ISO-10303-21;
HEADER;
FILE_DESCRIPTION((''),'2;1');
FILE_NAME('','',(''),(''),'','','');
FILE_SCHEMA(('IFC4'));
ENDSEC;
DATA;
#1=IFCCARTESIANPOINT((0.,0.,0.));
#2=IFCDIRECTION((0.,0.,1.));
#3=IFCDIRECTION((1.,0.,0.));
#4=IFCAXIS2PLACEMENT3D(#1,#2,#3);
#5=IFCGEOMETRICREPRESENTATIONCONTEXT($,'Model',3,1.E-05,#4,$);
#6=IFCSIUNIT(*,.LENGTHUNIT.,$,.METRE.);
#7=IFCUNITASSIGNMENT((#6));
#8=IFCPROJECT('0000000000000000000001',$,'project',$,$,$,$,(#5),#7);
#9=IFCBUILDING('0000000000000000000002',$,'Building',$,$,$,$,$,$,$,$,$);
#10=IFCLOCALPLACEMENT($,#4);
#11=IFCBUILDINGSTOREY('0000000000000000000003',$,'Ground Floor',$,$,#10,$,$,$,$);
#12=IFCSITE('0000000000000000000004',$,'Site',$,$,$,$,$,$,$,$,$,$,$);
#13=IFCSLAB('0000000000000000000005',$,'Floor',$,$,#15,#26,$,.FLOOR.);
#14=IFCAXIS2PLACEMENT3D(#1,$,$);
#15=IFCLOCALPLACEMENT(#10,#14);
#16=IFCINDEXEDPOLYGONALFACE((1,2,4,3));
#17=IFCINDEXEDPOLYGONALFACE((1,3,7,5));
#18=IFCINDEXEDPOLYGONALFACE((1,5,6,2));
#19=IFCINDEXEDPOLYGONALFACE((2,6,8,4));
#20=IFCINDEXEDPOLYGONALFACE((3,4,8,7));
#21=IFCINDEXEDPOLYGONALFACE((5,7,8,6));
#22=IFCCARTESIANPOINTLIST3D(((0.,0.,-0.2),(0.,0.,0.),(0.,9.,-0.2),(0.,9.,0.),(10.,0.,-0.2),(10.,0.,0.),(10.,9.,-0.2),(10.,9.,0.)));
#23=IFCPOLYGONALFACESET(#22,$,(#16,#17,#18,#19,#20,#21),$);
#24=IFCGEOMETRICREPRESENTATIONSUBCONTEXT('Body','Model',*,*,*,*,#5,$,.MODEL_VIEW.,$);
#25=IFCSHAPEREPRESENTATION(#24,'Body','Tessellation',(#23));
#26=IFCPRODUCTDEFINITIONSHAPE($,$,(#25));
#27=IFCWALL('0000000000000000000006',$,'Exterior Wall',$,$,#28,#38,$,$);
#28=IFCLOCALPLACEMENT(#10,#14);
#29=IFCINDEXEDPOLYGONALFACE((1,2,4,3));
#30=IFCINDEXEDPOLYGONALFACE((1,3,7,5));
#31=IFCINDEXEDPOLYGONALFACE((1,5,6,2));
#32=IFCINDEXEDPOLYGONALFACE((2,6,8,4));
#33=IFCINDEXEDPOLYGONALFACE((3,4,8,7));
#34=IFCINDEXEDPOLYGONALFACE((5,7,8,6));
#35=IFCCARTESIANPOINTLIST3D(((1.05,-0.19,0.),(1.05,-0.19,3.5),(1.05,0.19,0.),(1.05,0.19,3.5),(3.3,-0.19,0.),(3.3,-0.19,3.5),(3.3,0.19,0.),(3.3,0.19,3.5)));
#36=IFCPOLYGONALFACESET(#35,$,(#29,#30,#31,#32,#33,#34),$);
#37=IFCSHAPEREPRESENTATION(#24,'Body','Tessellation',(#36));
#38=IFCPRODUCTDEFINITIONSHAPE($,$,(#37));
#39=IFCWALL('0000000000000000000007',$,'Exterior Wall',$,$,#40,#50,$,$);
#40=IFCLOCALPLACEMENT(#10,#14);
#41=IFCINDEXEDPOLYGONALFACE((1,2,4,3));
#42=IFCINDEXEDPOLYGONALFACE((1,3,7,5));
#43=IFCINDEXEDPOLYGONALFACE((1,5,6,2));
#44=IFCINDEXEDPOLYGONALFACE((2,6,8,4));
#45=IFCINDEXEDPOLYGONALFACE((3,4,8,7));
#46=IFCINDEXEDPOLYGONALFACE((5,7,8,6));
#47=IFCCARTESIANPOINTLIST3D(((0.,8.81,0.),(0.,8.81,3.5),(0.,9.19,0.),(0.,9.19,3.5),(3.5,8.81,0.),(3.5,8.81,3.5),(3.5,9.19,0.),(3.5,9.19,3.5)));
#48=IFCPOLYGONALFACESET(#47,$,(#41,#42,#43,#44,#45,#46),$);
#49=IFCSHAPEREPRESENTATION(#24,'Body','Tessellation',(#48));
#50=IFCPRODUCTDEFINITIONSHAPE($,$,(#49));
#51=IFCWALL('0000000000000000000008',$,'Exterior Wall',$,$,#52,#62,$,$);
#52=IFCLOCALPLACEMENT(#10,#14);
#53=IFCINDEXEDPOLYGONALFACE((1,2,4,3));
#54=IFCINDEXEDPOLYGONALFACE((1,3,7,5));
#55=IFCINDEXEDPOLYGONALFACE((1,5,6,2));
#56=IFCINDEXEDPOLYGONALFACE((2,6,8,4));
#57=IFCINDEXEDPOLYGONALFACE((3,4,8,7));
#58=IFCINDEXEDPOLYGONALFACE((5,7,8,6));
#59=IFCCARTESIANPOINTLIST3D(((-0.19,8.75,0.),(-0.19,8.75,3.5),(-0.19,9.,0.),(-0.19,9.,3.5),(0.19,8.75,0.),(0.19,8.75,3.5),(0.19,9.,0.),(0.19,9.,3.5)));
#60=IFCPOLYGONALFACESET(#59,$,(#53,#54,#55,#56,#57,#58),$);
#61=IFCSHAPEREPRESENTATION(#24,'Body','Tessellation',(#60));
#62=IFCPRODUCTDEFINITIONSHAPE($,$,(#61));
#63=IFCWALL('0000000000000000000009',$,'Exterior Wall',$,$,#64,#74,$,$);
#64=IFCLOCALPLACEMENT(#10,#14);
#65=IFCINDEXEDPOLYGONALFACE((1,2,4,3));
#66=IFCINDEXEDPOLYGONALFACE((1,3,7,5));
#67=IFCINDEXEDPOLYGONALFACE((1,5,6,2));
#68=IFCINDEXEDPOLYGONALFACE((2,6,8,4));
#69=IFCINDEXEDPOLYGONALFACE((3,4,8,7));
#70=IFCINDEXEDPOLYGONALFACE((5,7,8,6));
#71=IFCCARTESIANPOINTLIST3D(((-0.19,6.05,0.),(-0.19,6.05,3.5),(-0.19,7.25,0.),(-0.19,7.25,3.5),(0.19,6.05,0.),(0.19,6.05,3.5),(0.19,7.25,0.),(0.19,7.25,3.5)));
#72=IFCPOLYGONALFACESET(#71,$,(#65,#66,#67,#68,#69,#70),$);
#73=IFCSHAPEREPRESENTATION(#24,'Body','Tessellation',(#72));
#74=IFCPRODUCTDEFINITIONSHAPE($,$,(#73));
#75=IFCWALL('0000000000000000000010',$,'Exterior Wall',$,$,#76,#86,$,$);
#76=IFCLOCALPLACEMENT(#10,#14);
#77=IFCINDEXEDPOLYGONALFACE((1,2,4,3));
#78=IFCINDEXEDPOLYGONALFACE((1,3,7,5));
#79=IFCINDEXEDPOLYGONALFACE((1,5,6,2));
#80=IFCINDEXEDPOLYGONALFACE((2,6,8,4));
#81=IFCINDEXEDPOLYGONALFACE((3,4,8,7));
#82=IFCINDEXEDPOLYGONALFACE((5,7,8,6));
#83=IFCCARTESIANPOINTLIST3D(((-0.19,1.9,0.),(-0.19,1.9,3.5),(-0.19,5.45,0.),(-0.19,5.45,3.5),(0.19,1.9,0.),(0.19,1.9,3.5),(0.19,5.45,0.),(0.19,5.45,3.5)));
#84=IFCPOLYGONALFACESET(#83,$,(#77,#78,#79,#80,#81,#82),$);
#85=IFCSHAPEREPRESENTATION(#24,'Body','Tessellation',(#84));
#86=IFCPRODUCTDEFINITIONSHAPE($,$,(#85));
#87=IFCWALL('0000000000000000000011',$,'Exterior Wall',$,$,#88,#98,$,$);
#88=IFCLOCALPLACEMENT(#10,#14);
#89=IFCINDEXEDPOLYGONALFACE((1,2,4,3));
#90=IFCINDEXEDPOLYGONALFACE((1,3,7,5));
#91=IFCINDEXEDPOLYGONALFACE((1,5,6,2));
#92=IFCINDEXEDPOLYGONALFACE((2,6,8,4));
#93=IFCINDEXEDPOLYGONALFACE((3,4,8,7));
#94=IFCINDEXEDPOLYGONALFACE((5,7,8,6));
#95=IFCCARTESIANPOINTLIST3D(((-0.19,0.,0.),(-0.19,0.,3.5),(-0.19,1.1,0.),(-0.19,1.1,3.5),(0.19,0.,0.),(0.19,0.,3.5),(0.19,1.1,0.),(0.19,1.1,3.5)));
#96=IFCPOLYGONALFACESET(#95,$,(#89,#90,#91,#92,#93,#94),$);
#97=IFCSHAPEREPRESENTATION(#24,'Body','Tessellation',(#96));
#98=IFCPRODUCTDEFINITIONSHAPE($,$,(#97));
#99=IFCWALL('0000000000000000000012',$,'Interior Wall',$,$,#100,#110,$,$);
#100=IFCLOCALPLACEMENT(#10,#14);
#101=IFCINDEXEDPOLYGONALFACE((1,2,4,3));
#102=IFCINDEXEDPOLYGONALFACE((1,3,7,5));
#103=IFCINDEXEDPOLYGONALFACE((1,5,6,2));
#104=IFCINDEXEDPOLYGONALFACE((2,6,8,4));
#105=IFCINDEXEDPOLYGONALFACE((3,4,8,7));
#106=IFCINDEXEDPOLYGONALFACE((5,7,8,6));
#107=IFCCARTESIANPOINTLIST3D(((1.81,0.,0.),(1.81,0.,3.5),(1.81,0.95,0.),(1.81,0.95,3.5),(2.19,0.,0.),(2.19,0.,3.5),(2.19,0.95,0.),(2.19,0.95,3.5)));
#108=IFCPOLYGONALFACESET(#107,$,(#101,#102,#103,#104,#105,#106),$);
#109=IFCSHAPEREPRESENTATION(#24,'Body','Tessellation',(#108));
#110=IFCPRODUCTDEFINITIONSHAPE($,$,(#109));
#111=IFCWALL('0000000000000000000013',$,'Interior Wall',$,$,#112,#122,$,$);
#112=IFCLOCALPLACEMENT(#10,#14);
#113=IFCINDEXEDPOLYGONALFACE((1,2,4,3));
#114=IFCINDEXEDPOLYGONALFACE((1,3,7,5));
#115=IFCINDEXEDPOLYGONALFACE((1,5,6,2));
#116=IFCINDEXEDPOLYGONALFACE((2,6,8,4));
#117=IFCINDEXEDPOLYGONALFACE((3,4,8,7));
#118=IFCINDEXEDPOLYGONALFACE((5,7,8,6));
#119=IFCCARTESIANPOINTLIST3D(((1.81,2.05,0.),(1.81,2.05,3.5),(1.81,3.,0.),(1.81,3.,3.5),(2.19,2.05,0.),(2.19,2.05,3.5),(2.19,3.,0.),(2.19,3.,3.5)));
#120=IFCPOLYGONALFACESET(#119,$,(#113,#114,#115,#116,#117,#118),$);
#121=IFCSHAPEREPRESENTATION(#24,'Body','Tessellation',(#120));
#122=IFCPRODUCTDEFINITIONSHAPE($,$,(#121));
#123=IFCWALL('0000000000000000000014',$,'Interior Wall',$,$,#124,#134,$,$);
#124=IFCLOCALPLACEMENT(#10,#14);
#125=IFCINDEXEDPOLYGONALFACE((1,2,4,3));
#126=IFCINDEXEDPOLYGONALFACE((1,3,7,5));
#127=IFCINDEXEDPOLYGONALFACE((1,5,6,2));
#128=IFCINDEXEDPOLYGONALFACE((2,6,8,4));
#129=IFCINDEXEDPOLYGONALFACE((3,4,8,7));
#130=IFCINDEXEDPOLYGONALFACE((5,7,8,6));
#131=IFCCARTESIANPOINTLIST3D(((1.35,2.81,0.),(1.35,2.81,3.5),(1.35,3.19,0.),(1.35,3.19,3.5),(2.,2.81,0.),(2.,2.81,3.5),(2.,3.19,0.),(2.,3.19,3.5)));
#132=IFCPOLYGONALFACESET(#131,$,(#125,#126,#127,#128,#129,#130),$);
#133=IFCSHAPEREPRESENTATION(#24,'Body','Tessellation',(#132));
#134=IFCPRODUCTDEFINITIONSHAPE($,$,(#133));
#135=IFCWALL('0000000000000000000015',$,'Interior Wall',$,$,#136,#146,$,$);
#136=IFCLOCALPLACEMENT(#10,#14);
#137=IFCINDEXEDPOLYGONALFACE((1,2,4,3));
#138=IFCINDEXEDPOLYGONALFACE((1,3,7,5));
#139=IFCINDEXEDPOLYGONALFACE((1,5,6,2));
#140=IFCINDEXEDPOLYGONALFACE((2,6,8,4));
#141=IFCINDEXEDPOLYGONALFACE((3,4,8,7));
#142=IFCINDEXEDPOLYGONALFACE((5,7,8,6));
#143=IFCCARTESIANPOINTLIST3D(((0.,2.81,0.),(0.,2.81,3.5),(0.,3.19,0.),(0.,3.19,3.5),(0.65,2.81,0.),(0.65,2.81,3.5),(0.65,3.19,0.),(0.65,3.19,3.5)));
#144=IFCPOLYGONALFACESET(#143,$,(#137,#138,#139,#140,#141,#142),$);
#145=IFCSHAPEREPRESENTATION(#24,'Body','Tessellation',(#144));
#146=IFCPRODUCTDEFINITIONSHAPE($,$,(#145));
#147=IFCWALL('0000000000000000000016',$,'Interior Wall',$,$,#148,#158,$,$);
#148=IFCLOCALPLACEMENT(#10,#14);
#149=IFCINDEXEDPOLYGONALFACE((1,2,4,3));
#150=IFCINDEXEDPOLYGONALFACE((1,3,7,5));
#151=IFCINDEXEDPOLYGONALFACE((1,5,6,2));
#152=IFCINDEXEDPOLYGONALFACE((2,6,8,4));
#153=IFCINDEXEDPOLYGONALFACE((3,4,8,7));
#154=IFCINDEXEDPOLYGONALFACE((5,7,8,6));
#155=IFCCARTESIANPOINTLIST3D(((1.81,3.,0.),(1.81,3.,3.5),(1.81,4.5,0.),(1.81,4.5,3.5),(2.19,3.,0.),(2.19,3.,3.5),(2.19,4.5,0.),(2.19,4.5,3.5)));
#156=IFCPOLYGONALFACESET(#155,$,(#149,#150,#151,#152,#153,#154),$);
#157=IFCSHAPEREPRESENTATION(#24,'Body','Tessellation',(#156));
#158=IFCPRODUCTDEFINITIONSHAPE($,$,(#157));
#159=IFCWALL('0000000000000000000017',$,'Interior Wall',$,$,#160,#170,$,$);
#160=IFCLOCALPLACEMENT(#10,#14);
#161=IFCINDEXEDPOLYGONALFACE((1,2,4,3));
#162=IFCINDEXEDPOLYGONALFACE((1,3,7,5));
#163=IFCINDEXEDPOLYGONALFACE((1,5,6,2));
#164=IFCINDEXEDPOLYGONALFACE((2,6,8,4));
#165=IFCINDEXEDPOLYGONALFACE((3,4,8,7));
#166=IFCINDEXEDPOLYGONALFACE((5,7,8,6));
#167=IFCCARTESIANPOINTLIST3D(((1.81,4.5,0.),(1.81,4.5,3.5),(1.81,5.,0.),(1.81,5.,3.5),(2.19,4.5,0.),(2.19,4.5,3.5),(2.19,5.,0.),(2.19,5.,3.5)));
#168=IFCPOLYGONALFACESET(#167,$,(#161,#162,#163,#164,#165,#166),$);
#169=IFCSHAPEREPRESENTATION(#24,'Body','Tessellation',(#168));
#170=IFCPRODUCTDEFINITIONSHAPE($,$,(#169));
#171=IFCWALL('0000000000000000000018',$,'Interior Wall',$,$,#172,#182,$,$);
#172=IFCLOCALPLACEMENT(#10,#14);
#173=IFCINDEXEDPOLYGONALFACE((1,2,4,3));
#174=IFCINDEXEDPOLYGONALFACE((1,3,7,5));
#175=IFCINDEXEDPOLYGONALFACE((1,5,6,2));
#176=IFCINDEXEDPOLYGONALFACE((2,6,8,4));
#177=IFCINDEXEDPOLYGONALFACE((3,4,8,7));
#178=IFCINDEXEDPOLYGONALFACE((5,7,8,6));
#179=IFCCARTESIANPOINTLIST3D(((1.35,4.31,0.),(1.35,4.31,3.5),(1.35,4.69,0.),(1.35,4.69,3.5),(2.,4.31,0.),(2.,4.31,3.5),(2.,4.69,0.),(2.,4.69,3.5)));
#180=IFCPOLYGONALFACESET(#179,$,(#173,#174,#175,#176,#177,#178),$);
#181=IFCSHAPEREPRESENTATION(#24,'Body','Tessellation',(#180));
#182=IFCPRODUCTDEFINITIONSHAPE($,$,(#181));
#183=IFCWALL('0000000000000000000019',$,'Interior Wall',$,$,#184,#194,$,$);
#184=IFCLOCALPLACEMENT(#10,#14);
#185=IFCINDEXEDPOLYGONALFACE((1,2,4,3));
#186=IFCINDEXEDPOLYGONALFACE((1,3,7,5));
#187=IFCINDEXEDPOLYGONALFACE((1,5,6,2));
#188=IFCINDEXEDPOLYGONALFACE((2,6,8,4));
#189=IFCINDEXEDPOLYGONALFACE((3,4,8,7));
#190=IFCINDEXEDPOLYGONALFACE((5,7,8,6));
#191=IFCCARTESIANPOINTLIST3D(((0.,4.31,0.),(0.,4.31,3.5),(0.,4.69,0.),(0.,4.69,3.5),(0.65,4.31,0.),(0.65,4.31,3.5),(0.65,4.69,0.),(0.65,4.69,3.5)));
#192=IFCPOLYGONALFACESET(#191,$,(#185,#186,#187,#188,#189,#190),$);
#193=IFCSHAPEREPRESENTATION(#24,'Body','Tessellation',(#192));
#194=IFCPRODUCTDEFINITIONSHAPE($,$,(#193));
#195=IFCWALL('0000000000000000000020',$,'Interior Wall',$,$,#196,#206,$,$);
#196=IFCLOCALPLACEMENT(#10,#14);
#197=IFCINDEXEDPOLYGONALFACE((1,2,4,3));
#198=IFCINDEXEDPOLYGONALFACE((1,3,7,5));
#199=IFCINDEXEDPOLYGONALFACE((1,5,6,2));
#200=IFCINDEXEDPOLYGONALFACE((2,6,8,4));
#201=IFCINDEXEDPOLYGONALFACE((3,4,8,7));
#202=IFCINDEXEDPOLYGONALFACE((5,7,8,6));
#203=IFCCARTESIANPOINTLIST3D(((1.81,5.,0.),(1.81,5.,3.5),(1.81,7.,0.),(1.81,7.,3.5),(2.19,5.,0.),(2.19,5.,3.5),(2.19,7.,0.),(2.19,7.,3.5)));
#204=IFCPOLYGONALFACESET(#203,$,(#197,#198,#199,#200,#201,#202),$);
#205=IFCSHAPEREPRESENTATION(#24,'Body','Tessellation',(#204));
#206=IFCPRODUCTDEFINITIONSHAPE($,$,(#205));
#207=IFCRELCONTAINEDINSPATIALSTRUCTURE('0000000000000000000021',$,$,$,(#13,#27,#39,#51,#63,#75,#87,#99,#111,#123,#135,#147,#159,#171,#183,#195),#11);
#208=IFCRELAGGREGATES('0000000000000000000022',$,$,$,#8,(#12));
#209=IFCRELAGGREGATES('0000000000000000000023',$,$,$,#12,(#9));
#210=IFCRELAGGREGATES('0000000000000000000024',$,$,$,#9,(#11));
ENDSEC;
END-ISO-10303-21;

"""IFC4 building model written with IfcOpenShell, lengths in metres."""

from ifc_helpers import new_model, si_unit, frame, origin_with_axes, place, context, subcontext, project, spatial, indexed_curve, outline, extrude, element, save


model = new_model("IFC4")

# Units and contexts
model_context = context("Model", 3, precision=1e-05, world=origin_with_axes())
body_context = subcontext(model_context, "Body", "Model", "MODEL_VIEW")
ifc_project = project(units=[si_unit("LENGTHUNIT", "METRE")], contexts=[model_context])

# Site, building, storey
site = spatial("IfcSite", under=ifc_project, Name="Site")
building = spatial("IfcBuilding", under=site, Name="Building")
storey_placement = place(None, origin_with_axes())
storey = spatial("IfcBuildingStorey", under=building, at=storey_placement, Name="Ground Floor")

# Slab
slab_placement = place(storey_placement, frame((0.0, 0.0, -0.2), z_axis=(0.0, 0.0, 1.0), x_axis=(1.0, 0.0, 0.0)))
element("IfcSlab", 1, at=slab_placement, inside=storey, Name="Floor", PredefinedType="FLOOR", context=body_context, shape_type="SweptSolid", body=[
    extrude(outline(indexed_curve([(0.0, 0.0), (10.0, 0.0), (10.0, 9.0), (0.0, 9.0)])), None, (0.0, 0.0, 1.0), 0.2),
])

# Walls
wall_1_placement = place(storey_placement, frame((1.05, 0.0, 0.0), z_axis=(0.0, 0.0, 1.0), x_axis=(1.0, 0.0, 0.0)))
element("IfcWall", 2, at=wall_1_placement, inside=storey, Name="Exterior Wall", context=body_context, shape_type="SweptSolid", body=[
    extrude(outline(indexed_curve([(0.0, 0.0), (0.0, 0.38), (2.25, 0.38), (2.25, 0.0), (0.0, 0.0)], self_intersect=False)), frame((0.0, -0.19, 0.0), z_axis=(0.0, 0.0, 1.0), x_axis=(1.0, 0.0, 0.0)), (0.0, 0.0, 1.0), 3.5),
])
wall_2_placement = place(storey_placement, frame((3.5, 9.0, 0.0), z_axis=(0.0, 0.0, 1.0), x_axis=(-1.0, 0.0, 0.0)))
element("IfcWall", 3, at=wall_2_placement, inside=storey, Name="Exterior Wall", context=body_context, shape_type="SweptSolid", body=[
    extrude(outline(indexed_curve([(0.0, 0.0), (0.0, 0.38), (3.5, 0.38), (3.5, 0.0), (0.0, 0.0)], self_intersect=False)), frame((0.0, -0.19, 0.0), z_axis=(0.0, 0.0, 1.0), x_axis=(1.0, 0.0, 0.0)), (0.0, 0.0, 1.0), 3.5),
])
wall_3_placement = place(storey_placement, frame((0.0, 9.0, 0.0), z_axis=(0.0, 0.0, 1.0), x_axis=(0.0, -1.0, 0.0)))
element("IfcWall", 4, at=wall_3_placement, inside=storey, Name="Exterior Wall", context=body_context, shape_type="SweptSolid", body=[
    extrude(outline(indexed_curve([(0.0, 0.0), (0.0, 0.38), (0.25, 0.38), (0.25, 0.0), (0.0, 0.0)], self_intersect=False)), frame((0.0, -0.19, 0.0), z_axis=(0.0, 0.0, 1.0), x_axis=(1.0, 0.0, 0.0)), (0.0, 0.0, 1.0), 3.5),
])
wall_4_placement = place(storey_placement, frame((0.0, 7.25, 0.0), z_axis=(0.0, 0.0, 1.0), x_axis=(0.0, -1.0, 0.0)))
element("IfcWall", 5, at=wall_4_placement, inside=storey, Name="Exterior Wall", context=body_context, shape_type="SweptSolid", body=[
    extrude(outline(indexed_curve([(0.0, 0.0), (0.0, 0.38), (1.2, 0.38), (1.2, 0.0), (0.0, 0.0)], self_intersect=False)), frame((0.0, -0.19, 0.0), z_axis=(0.0, 0.0, 1.0), x_axis=(1.0, 0.0, 0.0)), (0.0, 0.0, 1.0), 3.5),
])
wall_5_placement = place(storey_placement, frame((0.0, 5.45, 0.0), z_axis=(0.0, 0.0, 1.0), x_axis=(0.0, -1.0, 0.0)))
element("IfcWall", 6, at=wall_5_placement, inside=storey, Name="Exterior Wall", context=body_context, shape_type="SweptSolid", body=[
    extrude(outline(indexed_curve([(0.0, 0.0), (0.0, 0.38), (3.55, 0.38), (3.55, 0.0), (0.0, 0.0)], self_intersect=False)), frame((0.0, -0.19, 0.0), z_axis=(0.0, 0.0, 1.0), x_axis=(1.0, 0.0, 0.0)), (0.0, 0.0, 1.0), 3.5),
])
wall_6_placement = place(storey_placement, frame((0.0, 1.1, 0.0), z_axis=(0.0, 0.0, 1.0), x_axis=(0.0, -1.0, 0.0)))
element("IfcWall", 7, at=wall_6_placement, inside=storey, Name="Exterior Wall", context=body_context, shape_type="SweptSolid", body=[
    extrude(outline(indexed_curve([(0.0, 0.0), (0.0, 0.38), (1.1, 0.38), (1.1, 0.0), (0.0, 0.0)], self_intersect=False)), frame((0.0, -0.19, 0.0), z_axis=(0.0, 0.0, 1.0), x_axis=(1.0, 0.0, 0.0)), (0.0, 0.0, 1.0), 3.5),
])
wall_7_placement = place(storey_placement, frame((2.0, 0.0, 0.0), z_axis=(0.0, 0.0, 1.0), x_axis=(0.0, 1.0, 0.0)))
element("IfcWall", 8, at=wall_7_placement, inside=storey, Name="Interior Wall", context=body_context, shape_type="SweptSolid", body=[
    extrude(outline(indexed_curve([(0.0, 0.0), (0.0, 0.38), (0.95, 0.38), (0.95, 0.0), (0.0, 0.0)], self_intersect=False)), frame((0.0, -0.19, 0.0), z_axis=(0.0, 0.0, 1.0), x_axis=(1.0, 0.0, 0.0)), (0.0, 0.0, 1.0), 3.5),
])
wall_8_placement = place(storey_placement, frame((2.0, 2.05, 0.0), z_axis=(0.0, 0.0, 1.0), x_axis=(0.0, 1.0, 0.0)))
element("IfcWall", 9, at=wall_8_placement, inside=storey, Name="Interior Wall", context=body_context, shape_type="SweptSolid", body=[
    extrude(outline(indexed_curve([(0.0, 0.0), (0.0, 0.38), (0.95, 0.38), (0.95, 0.0), (0.0, 0.0)], self_intersect=False)), frame((0.0, -0.19, 0.0), z_axis=(0.0, 0.0, 1.0), x_axis=(1.0, 0.0, 0.0)), (0.0, 0.0, 1.0), 3.5),
])
for number, where, z_axis, x_axis, name in (
    (10, (2.0, 3.0, 0.0), (0.0, 0.0, 1.0), (-1.0, 0.0, 0.0), "Interior Wall"),
    (11, (0.65, 3.0, 0.0), (0.0, 0.0, 1.0), (-1.0, 0.0, 0.0), "Interior Wall"),
):
    element("IfcWall", number, at=place(storey_placement, frame(where, z_axis=z_axis, x_axis=x_axis)), inside=storey, Name=name, context=body_context, shape_type="SweptSolid", body=[
        extrude(outline(indexed_curve([(0.0, 0.0), (0.0, 0.38), (0.65, 0.38), (0.65, 0.0), (0.0, 0.0)], self_intersect=False)), frame((0.0, -0.19, 0.0), z_axis=(0.0, 0.0, 1.0), x_axis=(1.0, 0.0, 0.0)), (0.0, 0.0, 1.0), 3.5),
    ])
wall_9_placement = place(storey_placement, frame((2.0, 4.5, 0.0), z_axis=(0.0, 0.0, 1.0), x_axis=(0.0, -1.0, 0.0)))
element("IfcWall", 12, at=wall_9_placement, inside=storey, Name="Interior Wall", context=body_context, shape_type="SweptSolid", body=[
    extrude(outline(indexed_curve([(0.0, 0.0), (0.0, 0.38), (1.5, 0.38), (1.5, 0.0), (0.0, 0.0)], self_intersect=False)), frame((0.0, -0.19, 0.0), z_axis=(0.0, 0.0, 1.0), x_axis=(1.0, 0.0, 0.0)), (0.0, 0.0, 1.0), 3.5),
])
wall_10_placement = place(storey_placement, frame((2.0, 5.0, 0.0), z_axis=(0.0, 0.0, 1.0), x_axis=(0.0, -1.0, 0.0)))
element("IfcWall", 13, at=wall_10_placement, inside=storey, Name="Interior Wall", context=body_context, shape_type="SweptSolid", body=[
    extrude(outline(indexed_curve([(0.0, 0.0), (0.0, 0.38), (0.5, 0.38), (0.5, 0.0), (0.0, 0.0)], self_intersect=False)), frame((0.0, -0.19, 0.0), z_axis=(0.0, 0.0, 1.0), x_axis=(1.0, 0.0, 0.0)), (0.0, 0.0, 1.0), 3.5),
])
for number, where, z_axis, x_axis, name in (
    (14, (2.0, 4.5, 0.0), (0.0, 0.0, 1.0), (-1.0, 0.0, 0.0), "Interior Wall"),
    (15, (0.65, 4.5, 0.0), (0.0, 0.0, 1.0), (-1.0, 0.0, 0.0), "Interior Wall"),
):
    element("IfcWall", number, at=place(storey_placement, frame(where, z_axis=z_axis, x_axis=x_axis)), inside=storey, Name=name, context=body_context, shape_type="SweptSolid", body=[
        extrude(outline(indexed_curve([(0.0, 0.0), (0.0, 0.38), (0.65, 0.38), (0.65, 0.0), (0.0, 0.0)], self_intersect=False)), frame((0.0, -0.19, 0.0), z_axis=(0.0, 0.0, 1.0), x_axis=(1.0, 0.0, 0.0)), (0.0, 0.0, 1.0), 3.5),
    ])
wall_11_placement = place(storey_placement, frame((2.0, 5.0, 0.0), z_axis=(0.0, 0.0, 1.0), x_axis=(0.0, 1.0, 0.0)))
element("IfcWall", 16, at=wall_11_placement, inside=storey, Name="Interior Wall", context=body_context, shape_type="SweptSolid", body=[
    extrude(outline(indexed_curve([(0.0, 0.0), (0.0, 0.38), (2.0, 0.38), (2.0, 0.0), (0.0, 0.0)], self_intersect=False)), frame((0.0, -0.19, 0.0), z_axis=(0.0, 0.0, 1.0), x_axis=(1.0, 0.0, 0.0)), (0.0, 0.0, 1.0), 3.5),
])

save(model, "model.ifc")
